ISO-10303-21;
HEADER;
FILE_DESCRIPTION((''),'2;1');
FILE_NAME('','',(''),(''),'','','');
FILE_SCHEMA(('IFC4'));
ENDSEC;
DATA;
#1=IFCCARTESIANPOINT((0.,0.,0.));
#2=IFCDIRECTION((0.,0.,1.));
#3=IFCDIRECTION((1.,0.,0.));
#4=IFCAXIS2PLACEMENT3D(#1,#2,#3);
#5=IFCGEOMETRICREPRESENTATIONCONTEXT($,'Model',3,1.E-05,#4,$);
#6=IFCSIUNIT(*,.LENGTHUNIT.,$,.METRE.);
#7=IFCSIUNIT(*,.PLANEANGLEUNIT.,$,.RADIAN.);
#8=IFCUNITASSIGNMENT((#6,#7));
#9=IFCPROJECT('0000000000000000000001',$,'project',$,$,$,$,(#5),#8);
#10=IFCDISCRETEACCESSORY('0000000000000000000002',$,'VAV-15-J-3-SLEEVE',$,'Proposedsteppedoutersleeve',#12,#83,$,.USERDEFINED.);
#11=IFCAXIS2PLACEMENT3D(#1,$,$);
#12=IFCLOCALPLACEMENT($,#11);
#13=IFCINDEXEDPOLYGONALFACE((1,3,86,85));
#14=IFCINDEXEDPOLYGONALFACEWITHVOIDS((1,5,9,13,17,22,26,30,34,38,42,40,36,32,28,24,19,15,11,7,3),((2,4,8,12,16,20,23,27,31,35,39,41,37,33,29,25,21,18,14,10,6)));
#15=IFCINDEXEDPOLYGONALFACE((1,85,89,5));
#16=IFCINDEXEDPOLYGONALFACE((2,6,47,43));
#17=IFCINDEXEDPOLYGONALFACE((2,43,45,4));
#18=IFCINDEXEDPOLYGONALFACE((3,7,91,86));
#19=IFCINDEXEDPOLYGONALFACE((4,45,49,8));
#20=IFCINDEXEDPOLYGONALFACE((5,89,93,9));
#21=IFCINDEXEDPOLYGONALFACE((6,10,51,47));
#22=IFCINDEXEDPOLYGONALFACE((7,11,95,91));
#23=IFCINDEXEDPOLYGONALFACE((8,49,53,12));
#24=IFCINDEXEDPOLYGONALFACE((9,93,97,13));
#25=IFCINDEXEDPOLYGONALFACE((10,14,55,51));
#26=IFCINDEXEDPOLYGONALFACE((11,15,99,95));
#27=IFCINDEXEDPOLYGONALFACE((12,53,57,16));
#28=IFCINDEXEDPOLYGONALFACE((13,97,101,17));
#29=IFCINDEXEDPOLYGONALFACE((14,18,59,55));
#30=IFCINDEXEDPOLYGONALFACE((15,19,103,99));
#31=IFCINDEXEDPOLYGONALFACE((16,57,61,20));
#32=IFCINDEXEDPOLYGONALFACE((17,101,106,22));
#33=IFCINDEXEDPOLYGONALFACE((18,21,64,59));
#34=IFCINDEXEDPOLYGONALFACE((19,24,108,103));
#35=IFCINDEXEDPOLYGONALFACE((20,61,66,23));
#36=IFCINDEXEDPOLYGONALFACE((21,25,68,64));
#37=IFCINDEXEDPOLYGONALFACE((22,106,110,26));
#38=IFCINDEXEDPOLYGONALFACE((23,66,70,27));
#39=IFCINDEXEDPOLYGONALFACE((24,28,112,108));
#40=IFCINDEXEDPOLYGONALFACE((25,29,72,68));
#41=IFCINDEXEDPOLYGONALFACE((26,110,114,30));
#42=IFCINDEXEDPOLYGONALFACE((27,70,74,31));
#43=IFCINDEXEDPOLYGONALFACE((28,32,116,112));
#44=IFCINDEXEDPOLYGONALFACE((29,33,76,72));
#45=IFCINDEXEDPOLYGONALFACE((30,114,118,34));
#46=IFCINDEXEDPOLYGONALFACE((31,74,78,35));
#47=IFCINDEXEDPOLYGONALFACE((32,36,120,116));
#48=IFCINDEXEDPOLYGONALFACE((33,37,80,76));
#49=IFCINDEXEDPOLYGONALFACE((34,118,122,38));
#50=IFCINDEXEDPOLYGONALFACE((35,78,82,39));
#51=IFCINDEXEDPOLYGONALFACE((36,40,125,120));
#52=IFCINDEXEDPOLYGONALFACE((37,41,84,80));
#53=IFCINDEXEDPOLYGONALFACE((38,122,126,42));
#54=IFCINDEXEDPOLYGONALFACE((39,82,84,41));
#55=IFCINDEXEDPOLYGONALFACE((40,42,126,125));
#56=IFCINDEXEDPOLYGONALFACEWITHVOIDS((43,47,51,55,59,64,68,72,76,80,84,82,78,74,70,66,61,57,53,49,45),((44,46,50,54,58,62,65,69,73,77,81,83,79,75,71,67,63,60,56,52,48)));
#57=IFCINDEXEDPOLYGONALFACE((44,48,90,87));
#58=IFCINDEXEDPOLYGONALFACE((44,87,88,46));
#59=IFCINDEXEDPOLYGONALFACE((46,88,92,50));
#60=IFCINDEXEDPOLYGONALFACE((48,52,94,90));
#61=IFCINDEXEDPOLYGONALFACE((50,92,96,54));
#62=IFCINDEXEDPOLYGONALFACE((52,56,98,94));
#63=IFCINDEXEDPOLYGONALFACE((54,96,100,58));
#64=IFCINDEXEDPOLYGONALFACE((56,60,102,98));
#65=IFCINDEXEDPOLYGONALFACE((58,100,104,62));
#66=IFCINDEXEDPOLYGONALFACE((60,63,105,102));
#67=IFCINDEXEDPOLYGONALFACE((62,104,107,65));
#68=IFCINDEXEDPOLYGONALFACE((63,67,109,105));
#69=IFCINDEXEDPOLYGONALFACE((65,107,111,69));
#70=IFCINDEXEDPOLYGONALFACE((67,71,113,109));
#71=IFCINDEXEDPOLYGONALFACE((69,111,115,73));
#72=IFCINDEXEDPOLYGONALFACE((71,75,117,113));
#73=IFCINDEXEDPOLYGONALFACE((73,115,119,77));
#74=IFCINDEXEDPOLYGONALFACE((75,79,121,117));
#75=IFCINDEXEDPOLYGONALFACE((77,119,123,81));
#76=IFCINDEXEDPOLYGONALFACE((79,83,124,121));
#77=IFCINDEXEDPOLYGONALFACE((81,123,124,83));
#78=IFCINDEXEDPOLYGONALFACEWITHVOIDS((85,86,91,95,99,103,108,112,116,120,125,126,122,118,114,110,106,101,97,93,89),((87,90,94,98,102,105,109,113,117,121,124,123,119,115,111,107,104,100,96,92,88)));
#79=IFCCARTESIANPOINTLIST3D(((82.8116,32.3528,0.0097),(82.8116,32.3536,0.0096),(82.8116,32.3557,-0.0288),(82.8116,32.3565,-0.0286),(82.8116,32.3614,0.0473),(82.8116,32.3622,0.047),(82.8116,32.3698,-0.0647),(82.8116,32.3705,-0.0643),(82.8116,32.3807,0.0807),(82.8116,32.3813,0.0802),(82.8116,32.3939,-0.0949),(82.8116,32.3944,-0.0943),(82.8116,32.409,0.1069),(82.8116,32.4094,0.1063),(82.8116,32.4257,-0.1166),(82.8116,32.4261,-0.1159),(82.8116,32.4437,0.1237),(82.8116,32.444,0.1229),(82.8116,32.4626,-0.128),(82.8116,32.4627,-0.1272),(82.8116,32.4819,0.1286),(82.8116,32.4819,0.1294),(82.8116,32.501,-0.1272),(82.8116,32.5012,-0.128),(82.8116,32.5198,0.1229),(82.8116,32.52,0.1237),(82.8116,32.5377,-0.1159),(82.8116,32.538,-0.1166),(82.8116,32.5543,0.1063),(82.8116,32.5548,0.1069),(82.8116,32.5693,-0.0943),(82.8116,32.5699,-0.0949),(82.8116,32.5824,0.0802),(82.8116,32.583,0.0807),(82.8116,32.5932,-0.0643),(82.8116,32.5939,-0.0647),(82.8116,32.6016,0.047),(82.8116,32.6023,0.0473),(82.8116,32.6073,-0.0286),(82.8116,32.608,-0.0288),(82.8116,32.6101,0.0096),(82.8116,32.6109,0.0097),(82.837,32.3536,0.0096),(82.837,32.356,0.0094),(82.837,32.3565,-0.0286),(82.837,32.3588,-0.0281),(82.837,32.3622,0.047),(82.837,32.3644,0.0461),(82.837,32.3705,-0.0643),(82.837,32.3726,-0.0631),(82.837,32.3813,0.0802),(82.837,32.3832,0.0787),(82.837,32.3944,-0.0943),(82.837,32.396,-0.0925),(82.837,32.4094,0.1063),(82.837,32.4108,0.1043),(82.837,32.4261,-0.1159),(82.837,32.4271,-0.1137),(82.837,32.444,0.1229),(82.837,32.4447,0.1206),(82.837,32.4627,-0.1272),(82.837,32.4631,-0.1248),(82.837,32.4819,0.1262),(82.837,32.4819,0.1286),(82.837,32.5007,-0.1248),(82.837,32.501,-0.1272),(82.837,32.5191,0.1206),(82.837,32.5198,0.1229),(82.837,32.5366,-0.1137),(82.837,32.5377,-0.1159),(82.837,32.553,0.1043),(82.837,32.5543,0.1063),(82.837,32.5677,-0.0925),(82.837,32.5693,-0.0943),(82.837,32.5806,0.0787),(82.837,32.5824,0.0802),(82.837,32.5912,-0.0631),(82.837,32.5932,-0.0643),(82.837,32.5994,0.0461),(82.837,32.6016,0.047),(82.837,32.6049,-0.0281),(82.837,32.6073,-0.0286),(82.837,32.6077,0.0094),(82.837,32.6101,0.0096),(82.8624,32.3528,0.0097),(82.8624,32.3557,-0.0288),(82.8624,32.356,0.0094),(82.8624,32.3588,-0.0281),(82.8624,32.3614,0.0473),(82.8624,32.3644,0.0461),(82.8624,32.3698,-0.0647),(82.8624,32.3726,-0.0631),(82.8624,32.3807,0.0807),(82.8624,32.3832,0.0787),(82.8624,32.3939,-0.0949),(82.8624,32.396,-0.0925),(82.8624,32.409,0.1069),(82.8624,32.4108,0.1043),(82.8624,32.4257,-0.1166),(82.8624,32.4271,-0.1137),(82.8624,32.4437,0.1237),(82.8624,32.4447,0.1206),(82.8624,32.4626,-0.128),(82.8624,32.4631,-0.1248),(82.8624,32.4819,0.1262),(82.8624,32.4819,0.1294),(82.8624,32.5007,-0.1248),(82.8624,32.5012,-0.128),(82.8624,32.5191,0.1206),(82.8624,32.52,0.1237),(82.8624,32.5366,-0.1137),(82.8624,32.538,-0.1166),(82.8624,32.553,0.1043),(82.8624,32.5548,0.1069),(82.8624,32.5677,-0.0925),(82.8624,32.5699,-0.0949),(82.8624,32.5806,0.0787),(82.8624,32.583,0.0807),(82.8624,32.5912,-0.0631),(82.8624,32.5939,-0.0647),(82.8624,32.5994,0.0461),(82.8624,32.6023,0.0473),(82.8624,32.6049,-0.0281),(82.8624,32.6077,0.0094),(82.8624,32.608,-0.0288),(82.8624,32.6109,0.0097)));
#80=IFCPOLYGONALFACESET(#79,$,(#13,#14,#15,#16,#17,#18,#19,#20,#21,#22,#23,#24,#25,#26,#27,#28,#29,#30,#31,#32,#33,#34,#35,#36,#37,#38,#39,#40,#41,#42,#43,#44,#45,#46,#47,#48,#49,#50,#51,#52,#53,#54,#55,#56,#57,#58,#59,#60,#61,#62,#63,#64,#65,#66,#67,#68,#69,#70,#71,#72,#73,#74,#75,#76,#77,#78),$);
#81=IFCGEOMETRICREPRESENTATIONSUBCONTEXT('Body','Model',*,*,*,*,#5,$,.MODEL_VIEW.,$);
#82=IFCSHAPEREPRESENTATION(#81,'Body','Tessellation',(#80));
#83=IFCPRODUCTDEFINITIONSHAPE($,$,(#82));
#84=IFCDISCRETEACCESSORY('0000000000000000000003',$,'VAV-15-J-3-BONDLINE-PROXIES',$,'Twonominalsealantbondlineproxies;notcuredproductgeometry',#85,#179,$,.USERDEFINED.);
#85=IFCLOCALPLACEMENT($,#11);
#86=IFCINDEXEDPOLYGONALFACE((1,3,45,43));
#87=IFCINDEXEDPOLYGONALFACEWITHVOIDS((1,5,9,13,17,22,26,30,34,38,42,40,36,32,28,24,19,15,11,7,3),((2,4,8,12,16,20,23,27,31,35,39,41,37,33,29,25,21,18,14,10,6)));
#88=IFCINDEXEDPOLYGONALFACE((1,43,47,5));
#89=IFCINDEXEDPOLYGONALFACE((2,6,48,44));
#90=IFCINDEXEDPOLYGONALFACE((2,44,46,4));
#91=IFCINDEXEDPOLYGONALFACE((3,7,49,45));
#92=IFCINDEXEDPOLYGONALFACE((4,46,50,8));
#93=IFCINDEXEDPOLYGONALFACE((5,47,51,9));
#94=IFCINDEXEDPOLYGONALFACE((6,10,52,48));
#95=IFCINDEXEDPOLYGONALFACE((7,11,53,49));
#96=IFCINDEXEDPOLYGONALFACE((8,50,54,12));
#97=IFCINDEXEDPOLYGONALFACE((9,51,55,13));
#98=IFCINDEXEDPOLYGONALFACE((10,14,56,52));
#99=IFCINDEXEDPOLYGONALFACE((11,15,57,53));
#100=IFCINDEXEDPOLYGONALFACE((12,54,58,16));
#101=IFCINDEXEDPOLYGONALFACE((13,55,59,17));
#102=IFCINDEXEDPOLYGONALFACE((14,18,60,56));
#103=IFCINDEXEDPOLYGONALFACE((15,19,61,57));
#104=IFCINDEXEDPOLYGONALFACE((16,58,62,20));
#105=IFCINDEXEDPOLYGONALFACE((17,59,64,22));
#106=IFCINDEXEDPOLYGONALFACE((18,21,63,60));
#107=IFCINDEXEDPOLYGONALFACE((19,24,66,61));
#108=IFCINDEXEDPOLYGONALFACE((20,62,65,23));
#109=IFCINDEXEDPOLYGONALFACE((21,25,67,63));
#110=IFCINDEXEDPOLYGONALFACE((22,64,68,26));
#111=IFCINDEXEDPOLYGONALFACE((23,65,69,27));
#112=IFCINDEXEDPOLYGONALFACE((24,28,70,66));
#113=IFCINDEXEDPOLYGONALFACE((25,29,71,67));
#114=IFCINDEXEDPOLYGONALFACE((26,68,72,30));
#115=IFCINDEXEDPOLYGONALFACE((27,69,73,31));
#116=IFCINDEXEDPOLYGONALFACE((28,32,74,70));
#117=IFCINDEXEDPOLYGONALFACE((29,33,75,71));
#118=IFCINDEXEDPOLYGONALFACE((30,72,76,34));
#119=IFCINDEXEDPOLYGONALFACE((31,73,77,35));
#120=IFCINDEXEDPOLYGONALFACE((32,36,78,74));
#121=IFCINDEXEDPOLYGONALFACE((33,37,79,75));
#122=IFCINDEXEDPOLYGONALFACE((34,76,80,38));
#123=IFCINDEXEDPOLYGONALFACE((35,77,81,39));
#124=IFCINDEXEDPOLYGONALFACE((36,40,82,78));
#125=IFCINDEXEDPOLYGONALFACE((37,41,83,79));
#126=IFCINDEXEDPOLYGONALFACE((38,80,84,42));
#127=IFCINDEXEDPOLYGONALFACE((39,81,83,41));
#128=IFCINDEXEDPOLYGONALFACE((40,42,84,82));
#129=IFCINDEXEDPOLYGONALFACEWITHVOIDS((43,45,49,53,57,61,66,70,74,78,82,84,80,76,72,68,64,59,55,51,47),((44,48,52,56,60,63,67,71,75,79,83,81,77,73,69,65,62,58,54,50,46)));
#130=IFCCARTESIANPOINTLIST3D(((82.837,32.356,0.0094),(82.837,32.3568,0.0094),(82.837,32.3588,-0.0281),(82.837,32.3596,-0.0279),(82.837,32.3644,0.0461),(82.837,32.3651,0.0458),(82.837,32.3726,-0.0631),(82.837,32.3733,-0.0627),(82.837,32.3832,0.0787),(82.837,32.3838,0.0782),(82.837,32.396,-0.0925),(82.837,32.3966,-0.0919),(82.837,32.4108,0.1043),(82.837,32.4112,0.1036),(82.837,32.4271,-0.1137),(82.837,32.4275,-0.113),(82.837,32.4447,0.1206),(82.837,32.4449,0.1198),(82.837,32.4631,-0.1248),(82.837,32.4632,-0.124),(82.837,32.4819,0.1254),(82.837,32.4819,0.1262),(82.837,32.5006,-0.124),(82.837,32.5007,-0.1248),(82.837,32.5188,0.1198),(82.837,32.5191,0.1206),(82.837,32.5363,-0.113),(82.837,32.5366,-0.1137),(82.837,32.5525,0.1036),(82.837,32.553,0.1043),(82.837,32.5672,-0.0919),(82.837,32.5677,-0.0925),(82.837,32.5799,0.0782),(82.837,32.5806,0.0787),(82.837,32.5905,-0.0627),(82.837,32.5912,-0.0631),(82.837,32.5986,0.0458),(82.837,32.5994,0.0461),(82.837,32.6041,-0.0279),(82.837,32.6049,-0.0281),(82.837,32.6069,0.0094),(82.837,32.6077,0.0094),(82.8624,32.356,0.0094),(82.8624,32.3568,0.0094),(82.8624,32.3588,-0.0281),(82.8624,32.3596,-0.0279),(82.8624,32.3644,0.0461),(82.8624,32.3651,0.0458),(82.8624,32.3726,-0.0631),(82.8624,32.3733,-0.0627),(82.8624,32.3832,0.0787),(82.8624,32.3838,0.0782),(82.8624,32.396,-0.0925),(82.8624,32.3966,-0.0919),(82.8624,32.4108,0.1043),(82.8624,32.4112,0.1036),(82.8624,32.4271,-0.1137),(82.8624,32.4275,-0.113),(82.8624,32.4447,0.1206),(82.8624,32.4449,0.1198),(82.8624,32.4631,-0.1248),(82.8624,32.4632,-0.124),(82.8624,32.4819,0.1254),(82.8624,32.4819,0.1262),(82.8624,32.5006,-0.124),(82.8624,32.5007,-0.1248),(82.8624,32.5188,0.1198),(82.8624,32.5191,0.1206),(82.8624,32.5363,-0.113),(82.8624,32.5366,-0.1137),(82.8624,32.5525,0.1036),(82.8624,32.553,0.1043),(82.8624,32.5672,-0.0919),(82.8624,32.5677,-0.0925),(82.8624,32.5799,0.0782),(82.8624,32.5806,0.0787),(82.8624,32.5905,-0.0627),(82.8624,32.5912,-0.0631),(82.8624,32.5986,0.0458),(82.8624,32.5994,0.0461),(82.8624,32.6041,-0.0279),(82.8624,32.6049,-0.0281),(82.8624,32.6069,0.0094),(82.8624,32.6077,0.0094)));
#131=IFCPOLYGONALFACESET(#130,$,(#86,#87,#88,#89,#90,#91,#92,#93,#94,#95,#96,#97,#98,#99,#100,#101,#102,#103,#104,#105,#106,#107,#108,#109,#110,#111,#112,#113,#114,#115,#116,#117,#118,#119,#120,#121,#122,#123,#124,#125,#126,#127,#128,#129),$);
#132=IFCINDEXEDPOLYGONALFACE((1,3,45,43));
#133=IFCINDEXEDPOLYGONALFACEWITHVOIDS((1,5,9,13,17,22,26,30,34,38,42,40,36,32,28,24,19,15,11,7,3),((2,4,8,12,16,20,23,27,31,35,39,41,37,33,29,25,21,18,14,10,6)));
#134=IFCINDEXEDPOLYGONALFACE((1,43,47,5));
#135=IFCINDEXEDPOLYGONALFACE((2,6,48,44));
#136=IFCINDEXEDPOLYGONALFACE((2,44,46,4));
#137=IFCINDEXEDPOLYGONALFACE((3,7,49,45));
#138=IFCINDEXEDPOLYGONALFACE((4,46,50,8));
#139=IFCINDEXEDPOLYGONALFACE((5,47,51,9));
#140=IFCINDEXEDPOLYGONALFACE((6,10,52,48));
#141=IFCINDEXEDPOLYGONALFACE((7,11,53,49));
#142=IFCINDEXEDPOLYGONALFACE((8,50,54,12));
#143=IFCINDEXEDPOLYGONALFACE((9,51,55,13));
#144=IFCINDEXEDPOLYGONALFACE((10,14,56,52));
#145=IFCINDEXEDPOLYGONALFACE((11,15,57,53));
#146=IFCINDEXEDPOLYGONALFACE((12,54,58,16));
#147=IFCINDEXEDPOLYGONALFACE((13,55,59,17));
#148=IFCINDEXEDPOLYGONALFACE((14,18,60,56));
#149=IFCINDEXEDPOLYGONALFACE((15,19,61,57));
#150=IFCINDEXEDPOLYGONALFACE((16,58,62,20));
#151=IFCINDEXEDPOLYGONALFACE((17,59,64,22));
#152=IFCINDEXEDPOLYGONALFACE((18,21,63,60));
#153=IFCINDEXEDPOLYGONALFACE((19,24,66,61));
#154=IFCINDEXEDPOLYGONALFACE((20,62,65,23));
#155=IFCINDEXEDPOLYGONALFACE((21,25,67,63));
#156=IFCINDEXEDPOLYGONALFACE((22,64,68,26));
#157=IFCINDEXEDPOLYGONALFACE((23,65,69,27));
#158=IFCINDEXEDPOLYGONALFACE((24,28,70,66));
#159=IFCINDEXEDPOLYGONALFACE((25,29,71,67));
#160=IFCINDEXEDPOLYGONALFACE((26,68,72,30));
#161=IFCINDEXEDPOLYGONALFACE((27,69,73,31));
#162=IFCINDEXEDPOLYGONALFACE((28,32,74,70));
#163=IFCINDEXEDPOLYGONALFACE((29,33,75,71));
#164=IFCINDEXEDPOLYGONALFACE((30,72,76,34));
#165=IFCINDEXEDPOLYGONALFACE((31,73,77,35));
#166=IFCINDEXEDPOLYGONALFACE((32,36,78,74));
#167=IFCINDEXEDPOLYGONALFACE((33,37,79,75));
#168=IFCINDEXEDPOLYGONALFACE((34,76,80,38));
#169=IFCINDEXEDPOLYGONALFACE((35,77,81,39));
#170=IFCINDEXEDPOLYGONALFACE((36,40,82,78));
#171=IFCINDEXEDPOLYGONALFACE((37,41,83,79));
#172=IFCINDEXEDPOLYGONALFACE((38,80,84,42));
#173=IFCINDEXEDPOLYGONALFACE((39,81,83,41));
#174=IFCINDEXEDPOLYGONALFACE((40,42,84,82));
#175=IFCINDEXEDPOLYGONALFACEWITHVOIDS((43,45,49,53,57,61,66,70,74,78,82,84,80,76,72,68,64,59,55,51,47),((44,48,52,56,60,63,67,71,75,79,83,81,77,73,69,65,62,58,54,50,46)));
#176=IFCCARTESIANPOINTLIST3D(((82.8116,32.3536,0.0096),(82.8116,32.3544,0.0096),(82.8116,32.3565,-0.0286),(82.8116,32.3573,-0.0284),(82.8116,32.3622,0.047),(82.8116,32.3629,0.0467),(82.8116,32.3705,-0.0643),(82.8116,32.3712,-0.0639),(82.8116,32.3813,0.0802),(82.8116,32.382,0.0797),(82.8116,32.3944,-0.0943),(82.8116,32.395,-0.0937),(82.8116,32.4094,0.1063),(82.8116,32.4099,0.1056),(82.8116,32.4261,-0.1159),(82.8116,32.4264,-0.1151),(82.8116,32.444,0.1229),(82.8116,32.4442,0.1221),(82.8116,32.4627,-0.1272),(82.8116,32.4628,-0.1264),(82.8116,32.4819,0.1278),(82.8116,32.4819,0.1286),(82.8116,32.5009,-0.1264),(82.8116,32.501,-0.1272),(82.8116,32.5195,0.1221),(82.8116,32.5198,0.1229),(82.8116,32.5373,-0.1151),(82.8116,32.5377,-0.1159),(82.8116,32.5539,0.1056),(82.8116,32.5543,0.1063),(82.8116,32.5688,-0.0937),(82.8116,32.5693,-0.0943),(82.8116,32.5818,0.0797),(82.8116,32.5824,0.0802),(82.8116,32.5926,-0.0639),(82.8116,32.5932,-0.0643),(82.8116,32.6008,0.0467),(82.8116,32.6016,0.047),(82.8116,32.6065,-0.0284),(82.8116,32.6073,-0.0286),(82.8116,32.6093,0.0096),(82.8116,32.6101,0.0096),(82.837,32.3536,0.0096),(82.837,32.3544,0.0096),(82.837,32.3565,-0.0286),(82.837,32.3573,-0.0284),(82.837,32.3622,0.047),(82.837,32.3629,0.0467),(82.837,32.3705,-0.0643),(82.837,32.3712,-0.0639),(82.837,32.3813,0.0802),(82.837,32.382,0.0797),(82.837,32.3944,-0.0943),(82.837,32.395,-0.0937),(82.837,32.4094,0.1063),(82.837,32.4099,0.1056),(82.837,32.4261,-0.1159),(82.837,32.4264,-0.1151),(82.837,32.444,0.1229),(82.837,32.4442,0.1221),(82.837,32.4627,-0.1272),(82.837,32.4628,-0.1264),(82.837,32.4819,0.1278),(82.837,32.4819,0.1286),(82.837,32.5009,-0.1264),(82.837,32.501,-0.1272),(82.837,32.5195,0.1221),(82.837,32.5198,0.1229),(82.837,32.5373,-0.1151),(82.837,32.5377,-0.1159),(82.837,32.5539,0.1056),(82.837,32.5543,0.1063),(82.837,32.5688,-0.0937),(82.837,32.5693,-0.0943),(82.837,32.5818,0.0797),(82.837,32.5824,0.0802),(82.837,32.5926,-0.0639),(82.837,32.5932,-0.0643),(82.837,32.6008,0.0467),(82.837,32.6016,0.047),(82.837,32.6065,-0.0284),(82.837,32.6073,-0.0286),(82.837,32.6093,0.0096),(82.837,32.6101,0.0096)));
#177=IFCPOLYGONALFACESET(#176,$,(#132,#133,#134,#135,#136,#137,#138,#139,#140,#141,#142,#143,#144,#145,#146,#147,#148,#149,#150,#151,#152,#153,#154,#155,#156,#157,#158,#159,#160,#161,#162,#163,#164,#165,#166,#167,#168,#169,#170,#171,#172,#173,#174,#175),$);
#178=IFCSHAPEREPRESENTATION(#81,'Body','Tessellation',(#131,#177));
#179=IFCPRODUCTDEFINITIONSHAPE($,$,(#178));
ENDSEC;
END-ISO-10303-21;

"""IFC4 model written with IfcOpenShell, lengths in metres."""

from ifc_helpers import new_model, entity, si_unit, frame, origin_with_axes, place, context, subcontext, project, element, save


model = new_model("IFC4")

# Units and contexts
model_context = context("Model", 3, precision=1e-05, world=origin_with_axes())
body_context = subcontext(model_context, "Body", "Model", "MODEL_VIEW")
ifc_project = project(units=[si_unit("LENGTHUNIT", "METRE"), si_unit("PLANEANGLEUNIT", "RADIAN")], contexts=[model_context])

# Discrete accessories
discrete_accessory_1_placement = place(None, frame((82.837, 32.4819, 0.0), z_axis=(0.0, -1.0, 0.0), x_axis=(0.0, 0.0, 1.0)))
element("IfcDiscreteAccessory", 1, at=discrete_accessory_1_placement, Name="VAV-15-J-3-SLEEVE", ObjectType="Proposedsteppedoutersleeve", PredefinedType="USERDEFINED", context=body_context, shape_type="SweptSolid", body=[
    entity("IfcRevolvedAreaSolid", entity("IfcArbitraryClosedProfileDef", "AREA", None, entity("IfcPolyline", [entity("IfcCartesianPoint", [0.1262, -0.0254]), entity("IfcCartesianPoint", [0.1294, -0.0254]), entity("IfcCartesianPoint", [0.1294, 0.0254]), entity("IfcCartesianPoint", [0.1286, 0.0254]), entity("IfcCartesianPoint", [0.1286, 0.0]), entity("IfcCartesianPoint", [0.1262, 0.0]), entity("IfcCartesianPoint", [0.1262, -0.0254])])), entity("IfcAxis2Placement3D", entity("IfcCartesianPoint", [0.0, 0.0, 0.0])), entity("IfcAxis1Placement", entity("IfcCartesianPoint", [0.0, 0.0, 0.0]), entity("IfcDirection", [0.0, 1.0, 0.0])), 6.283185),
])
discrete_accessory_2_placement = place(None, frame((82.837, 32.4819, 0.0), z_axis=(0.0, -1.0, 0.0), x_axis=(0.0, 0.0, 1.0)))
element("IfcDiscreteAccessory", 2, at=discrete_accessory_2_placement, Name="VAV-15-J-3-BONDLINE-PROXIES", ObjectType="Twonominalsealantbondlineproxies;notcuredproductgeometry", PredefinedType="USERDEFINED", context=body_context, shape_type="SweptSolid", body=[
    entity("IfcRevolvedAreaSolid", entity("IfcArbitraryClosedProfileDef", "AREA", None, entity("IfcPolyline", [entity("IfcCartesianPoint", [0.1254, -0.0254]), entity("IfcCartesianPoint", [0.1262, -0.0254]), entity("IfcCartesianPoint", [0.1262, 0.0]), entity("IfcCartesianPoint", [0.1254, 0.0]), entity("IfcCartesianPoint", [0.1254, -0.0254])])), entity("IfcAxis2Placement3D", entity("IfcCartesianPoint", [0.0, 0.0, 0.0])), entity("IfcAxis1Placement", entity("IfcCartesianPoint", [0.0, 0.0, 0.0]), entity("IfcDirection", [0.0, 1.0, 0.0])), 6.283185),
    entity("IfcRevolvedAreaSolid", entity("IfcArbitraryClosedProfileDef", "AREA", None, entity("IfcPolyline", [entity("IfcCartesianPoint", [0.1278, 0.0]), entity("IfcCartesianPoint", [0.1286, 0.0]), entity("IfcCartesianPoint", [0.1286, 0.0254]), entity("IfcCartesianPoint", [0.1278, 0.0254]), entity("IfcCartesianPoint", [0.1278, 0.0])])), entity("IfcAxis2Placement3D", entity("IfcCartesianPoint", [0.0, 0.0, 0.0])), entity("IfcAxis1Placement", entity("IfcCartesianPoint", [0.0, 0.0, 0.0]), entity("IfcDirection", [0.0, 1.0, 0.0])), 6.283185),
])

save(model, "model.ifc")
